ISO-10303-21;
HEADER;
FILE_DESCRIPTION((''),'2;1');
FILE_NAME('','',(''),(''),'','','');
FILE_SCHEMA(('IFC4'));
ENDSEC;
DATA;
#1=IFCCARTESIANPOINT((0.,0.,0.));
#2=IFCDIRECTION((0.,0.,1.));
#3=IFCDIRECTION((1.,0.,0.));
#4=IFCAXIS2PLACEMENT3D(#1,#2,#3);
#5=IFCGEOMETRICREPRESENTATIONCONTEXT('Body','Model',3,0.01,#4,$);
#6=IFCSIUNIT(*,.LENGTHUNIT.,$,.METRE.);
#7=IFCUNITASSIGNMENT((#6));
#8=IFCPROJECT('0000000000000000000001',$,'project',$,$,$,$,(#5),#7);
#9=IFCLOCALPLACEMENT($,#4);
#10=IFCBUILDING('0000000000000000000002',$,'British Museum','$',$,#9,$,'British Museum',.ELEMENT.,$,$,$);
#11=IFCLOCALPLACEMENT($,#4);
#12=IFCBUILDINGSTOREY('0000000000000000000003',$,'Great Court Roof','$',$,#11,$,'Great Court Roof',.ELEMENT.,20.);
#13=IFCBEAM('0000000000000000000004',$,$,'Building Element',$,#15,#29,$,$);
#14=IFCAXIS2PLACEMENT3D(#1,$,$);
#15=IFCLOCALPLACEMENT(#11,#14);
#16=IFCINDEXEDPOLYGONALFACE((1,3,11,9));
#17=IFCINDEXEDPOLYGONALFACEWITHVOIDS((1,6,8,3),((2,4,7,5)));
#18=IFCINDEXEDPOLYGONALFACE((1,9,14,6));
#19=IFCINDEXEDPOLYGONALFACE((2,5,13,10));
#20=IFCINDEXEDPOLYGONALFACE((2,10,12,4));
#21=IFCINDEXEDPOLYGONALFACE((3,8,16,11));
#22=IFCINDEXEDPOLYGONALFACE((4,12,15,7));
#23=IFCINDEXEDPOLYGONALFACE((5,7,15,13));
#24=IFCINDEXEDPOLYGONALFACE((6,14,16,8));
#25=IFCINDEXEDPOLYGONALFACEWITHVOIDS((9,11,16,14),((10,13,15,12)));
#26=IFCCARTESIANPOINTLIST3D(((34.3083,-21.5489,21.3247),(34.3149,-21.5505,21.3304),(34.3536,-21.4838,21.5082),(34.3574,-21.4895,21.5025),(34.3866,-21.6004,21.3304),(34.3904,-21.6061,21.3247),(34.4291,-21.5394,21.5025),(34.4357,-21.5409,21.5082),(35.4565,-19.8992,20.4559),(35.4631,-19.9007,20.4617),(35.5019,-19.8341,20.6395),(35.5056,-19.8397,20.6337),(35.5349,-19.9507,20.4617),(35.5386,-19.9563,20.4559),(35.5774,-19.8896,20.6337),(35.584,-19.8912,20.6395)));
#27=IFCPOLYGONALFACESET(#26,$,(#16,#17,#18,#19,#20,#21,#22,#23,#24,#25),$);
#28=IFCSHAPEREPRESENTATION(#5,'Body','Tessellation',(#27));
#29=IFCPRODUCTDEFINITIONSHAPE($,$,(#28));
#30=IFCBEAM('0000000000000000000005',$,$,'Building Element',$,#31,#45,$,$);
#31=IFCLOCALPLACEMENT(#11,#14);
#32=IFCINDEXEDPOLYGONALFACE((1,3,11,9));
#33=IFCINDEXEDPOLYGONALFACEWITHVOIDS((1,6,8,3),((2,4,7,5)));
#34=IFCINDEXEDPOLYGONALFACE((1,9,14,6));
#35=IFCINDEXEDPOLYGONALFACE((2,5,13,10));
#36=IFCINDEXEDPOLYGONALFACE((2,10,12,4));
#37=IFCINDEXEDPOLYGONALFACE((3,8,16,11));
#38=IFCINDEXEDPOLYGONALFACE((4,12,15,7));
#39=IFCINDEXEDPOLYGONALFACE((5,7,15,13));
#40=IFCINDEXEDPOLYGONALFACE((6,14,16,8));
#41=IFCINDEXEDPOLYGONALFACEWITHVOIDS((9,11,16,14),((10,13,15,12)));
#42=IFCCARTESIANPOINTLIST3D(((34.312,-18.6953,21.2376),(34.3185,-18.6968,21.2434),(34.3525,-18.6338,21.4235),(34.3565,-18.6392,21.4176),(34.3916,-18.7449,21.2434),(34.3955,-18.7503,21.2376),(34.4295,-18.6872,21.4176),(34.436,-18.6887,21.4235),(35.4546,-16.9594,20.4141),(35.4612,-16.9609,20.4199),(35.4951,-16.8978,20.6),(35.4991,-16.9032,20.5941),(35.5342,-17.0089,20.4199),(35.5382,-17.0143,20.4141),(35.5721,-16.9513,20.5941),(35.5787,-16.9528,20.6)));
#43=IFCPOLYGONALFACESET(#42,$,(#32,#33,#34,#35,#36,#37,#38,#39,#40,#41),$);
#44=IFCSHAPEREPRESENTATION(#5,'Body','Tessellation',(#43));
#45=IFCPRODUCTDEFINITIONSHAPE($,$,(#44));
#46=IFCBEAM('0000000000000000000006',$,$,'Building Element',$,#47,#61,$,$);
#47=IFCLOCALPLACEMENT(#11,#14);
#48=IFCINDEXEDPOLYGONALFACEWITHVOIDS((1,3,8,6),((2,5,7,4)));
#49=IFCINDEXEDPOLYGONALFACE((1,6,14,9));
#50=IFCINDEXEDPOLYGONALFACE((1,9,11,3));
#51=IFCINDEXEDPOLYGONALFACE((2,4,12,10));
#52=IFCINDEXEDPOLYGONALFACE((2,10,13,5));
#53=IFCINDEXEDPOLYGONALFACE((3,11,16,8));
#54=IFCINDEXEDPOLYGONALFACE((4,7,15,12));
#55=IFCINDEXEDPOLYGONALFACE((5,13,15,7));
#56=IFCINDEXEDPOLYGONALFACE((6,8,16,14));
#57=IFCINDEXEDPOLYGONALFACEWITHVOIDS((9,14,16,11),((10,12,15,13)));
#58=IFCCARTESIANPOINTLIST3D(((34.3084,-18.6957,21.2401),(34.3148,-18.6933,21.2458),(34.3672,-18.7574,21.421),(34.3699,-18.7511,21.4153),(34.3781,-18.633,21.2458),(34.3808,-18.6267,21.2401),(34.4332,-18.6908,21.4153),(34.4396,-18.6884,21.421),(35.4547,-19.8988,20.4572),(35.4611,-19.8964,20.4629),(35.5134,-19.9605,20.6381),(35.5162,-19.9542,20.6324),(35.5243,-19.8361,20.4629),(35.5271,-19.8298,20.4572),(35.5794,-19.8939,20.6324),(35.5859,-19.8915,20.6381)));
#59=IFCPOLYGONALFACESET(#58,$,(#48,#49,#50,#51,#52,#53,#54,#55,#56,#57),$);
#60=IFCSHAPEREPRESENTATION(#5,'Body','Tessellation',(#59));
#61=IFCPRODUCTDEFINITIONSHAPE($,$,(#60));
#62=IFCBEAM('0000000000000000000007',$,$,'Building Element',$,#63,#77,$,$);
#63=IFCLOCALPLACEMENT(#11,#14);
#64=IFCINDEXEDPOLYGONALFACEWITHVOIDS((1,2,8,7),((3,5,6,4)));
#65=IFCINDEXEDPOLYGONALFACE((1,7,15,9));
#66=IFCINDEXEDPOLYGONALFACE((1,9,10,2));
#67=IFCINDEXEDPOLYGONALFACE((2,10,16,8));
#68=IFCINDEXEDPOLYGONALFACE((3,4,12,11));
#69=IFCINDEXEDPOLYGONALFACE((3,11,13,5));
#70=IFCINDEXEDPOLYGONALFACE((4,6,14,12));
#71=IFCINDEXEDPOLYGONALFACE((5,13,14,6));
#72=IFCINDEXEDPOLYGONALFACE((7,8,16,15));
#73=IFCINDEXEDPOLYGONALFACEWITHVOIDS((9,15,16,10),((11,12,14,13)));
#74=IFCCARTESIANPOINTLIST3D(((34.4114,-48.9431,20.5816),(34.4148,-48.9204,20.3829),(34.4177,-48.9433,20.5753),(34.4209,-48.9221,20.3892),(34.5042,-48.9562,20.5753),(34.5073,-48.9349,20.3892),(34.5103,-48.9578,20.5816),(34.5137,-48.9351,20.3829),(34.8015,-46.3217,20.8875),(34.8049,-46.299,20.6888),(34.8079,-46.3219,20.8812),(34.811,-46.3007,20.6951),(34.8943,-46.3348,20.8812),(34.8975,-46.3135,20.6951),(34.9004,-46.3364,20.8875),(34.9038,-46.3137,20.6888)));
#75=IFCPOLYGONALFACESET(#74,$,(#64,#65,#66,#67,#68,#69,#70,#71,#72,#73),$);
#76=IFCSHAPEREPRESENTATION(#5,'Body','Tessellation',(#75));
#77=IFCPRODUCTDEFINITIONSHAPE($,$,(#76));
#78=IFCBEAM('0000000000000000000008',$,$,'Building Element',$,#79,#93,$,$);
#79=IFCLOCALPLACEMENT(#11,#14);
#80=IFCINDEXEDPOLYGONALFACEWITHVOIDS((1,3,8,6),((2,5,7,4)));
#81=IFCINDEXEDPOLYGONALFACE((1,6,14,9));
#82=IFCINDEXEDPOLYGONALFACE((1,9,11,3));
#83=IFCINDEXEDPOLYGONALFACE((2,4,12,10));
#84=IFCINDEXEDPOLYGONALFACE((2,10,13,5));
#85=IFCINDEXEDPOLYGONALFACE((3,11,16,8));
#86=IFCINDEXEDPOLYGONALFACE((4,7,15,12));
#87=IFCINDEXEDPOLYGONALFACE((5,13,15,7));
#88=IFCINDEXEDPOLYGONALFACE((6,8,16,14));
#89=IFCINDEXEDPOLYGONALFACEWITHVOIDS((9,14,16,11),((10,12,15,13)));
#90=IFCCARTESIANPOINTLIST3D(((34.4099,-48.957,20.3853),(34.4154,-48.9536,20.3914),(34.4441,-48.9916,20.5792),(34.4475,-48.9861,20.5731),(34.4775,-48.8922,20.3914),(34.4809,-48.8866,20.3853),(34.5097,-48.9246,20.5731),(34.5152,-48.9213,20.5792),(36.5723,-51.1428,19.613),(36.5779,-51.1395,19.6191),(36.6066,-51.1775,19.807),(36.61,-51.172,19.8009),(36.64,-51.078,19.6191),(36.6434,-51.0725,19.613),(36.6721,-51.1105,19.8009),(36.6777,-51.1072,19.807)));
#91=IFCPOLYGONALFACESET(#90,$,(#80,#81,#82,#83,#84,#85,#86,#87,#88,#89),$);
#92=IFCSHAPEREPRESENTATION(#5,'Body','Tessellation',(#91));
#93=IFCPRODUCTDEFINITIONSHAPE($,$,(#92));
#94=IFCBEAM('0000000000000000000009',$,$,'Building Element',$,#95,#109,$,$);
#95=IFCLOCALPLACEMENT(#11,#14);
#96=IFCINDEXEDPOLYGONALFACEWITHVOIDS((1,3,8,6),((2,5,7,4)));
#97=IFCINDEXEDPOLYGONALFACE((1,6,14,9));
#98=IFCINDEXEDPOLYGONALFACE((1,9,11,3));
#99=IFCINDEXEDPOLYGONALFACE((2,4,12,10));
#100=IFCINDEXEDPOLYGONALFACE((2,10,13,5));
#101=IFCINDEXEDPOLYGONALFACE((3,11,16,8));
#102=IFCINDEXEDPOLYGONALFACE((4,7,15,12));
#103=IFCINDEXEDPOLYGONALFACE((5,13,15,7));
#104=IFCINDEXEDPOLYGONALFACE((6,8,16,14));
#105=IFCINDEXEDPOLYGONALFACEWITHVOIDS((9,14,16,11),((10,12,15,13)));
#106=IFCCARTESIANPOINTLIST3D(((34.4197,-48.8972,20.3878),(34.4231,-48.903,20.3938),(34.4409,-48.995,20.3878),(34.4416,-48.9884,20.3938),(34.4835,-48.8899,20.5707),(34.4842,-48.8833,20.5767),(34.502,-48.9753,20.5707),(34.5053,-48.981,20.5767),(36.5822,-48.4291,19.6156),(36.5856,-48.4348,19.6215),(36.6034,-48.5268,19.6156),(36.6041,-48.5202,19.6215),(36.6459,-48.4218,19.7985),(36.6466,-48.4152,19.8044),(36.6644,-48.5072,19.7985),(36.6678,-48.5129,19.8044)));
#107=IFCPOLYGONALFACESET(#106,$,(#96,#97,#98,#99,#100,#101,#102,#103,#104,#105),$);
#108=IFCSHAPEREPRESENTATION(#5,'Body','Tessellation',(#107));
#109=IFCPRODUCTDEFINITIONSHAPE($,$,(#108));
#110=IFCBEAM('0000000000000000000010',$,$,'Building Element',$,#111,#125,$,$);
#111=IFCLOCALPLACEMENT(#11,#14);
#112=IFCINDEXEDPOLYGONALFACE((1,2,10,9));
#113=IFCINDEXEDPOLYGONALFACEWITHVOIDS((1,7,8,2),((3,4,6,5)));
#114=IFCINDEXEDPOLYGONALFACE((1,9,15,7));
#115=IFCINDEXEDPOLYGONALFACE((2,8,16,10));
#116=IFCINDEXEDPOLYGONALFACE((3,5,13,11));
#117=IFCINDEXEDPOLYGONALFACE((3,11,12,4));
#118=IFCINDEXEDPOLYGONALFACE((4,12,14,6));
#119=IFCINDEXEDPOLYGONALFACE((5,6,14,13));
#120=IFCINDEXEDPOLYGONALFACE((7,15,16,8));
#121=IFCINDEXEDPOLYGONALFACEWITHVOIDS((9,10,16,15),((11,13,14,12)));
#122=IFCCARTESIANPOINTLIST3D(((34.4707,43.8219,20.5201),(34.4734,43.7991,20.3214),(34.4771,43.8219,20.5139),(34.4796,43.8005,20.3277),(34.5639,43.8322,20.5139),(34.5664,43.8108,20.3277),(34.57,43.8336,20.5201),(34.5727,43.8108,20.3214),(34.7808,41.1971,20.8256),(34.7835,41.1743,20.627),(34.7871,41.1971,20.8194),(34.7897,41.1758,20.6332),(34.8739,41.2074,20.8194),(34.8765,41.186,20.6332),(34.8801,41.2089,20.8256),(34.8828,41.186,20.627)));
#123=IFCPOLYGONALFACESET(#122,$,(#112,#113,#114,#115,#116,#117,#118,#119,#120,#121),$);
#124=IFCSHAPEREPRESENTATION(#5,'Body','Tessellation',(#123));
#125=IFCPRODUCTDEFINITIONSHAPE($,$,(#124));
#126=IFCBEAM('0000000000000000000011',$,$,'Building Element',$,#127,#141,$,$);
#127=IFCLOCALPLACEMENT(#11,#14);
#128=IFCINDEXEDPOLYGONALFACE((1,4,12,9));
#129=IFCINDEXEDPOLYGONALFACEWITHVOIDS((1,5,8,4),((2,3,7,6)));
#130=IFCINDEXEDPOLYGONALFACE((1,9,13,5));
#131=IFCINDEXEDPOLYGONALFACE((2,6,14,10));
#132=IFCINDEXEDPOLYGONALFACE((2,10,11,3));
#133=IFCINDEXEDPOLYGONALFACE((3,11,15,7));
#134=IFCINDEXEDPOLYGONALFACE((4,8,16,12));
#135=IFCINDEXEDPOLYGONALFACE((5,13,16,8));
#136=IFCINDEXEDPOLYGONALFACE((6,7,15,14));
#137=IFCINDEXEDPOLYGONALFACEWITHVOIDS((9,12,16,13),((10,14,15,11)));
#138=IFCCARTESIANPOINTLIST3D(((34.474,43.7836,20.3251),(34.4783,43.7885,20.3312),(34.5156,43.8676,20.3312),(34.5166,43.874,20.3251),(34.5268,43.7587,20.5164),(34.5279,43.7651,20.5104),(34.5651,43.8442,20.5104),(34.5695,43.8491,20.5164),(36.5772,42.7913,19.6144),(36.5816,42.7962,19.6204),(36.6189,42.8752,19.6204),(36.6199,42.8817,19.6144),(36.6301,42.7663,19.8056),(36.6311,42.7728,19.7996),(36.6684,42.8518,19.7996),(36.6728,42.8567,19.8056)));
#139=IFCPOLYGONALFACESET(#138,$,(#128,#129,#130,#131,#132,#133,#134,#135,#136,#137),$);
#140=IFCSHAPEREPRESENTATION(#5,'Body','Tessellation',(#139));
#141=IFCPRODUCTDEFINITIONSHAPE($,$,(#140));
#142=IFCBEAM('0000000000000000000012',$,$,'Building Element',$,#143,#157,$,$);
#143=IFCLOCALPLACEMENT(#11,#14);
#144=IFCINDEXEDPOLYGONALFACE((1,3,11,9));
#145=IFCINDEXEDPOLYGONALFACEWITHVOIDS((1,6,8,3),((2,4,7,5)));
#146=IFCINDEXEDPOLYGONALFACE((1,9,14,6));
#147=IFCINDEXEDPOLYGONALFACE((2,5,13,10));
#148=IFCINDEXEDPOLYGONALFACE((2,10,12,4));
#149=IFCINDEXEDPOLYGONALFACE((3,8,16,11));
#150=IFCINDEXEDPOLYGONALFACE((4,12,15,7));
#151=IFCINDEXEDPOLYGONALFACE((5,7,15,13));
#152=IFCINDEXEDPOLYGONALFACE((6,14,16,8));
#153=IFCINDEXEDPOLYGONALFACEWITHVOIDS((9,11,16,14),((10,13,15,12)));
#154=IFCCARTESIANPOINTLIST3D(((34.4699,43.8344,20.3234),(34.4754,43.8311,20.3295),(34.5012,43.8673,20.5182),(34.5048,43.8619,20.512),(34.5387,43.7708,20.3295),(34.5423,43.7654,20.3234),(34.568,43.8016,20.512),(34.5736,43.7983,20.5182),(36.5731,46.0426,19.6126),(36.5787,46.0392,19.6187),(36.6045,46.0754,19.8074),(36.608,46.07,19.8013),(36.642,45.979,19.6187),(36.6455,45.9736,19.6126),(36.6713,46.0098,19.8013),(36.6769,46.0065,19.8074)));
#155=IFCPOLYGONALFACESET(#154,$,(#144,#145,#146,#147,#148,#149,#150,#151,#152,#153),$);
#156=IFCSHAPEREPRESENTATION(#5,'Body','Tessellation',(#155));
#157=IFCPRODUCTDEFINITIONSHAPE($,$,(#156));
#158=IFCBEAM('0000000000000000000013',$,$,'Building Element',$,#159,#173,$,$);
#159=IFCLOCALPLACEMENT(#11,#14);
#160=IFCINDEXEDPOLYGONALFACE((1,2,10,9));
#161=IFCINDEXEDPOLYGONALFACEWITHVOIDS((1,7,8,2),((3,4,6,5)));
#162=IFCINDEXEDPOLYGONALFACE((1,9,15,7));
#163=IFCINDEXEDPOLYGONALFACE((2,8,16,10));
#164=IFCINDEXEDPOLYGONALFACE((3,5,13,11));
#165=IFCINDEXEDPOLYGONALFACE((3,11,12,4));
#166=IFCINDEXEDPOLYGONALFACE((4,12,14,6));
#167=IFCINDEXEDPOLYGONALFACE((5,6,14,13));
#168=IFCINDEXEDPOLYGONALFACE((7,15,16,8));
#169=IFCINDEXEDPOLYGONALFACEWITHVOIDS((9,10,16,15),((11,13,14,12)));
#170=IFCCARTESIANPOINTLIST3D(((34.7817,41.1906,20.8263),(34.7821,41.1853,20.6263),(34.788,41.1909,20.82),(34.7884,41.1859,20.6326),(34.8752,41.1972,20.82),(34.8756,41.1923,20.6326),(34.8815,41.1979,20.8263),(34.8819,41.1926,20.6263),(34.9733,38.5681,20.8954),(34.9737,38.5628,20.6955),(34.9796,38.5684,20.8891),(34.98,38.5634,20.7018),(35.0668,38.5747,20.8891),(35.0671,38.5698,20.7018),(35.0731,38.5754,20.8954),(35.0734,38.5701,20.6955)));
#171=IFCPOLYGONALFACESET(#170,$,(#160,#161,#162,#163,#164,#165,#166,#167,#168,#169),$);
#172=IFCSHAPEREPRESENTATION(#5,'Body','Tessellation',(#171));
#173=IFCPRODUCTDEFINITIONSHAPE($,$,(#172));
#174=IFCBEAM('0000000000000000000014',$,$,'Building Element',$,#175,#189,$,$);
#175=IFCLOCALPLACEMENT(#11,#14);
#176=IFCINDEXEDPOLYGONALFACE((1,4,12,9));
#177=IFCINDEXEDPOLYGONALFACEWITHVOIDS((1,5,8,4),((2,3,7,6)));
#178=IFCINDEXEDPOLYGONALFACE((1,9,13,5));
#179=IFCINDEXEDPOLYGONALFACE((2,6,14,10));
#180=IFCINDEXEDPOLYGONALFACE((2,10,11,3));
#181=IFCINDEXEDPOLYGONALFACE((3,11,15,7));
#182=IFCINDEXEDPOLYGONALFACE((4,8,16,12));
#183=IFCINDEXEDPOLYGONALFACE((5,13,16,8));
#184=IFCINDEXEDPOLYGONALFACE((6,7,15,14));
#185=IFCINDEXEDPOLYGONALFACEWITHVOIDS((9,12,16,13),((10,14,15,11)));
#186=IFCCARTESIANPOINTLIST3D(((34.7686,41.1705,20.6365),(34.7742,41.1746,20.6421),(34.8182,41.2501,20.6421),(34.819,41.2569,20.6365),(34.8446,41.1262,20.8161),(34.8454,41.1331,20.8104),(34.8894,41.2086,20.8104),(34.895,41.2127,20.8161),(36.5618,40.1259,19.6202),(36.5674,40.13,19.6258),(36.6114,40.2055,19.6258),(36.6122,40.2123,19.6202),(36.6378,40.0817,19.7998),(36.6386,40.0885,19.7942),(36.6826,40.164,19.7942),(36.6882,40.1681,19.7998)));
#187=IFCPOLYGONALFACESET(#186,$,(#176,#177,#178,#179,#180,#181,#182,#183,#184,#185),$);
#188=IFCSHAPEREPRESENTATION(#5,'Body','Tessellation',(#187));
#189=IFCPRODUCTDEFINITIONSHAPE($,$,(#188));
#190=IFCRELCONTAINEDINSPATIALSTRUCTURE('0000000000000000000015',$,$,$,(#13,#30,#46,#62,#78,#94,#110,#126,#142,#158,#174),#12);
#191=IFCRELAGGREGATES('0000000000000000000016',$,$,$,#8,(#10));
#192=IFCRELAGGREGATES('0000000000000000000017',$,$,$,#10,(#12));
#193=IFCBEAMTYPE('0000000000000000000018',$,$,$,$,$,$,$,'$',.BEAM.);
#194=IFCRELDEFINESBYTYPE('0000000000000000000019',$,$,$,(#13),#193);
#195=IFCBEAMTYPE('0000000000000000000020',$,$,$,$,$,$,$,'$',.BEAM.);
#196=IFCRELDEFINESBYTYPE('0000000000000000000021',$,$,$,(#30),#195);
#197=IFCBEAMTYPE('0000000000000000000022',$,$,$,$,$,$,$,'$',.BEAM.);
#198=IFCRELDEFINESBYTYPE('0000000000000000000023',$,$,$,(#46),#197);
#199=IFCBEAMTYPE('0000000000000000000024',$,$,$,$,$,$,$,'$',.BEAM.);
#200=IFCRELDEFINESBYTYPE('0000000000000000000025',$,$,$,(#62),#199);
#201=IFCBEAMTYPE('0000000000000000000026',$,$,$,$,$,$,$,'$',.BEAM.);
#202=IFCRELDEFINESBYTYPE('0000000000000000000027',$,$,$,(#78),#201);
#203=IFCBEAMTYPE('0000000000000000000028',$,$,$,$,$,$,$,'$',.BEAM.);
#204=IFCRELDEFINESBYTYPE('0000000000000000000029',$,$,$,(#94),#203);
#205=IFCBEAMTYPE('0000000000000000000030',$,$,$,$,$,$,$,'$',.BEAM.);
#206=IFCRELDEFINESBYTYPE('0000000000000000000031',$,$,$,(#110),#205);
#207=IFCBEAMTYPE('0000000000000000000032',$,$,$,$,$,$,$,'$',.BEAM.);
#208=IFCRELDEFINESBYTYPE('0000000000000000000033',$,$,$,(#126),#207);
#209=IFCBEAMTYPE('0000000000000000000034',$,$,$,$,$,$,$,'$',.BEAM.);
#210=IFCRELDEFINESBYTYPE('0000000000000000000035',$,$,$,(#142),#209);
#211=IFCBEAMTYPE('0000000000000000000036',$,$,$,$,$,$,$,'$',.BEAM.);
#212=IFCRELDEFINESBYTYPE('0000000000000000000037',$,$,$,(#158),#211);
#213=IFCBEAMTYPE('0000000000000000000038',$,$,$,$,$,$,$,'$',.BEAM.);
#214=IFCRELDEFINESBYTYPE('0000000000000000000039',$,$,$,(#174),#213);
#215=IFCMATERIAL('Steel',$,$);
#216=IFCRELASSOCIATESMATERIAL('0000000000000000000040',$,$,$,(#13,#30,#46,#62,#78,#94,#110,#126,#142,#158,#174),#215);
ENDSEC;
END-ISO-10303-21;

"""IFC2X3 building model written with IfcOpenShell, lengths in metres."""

from ifc_helpers import new_model, si_unit, frame, origin_with_axes, origin_2d, place, context, project, spatial, hollow_rectangle, extrude, material, type_object, element, save


model = new_model("IFC2X3")

# Units and contexts
model_context = context("Model", 3, precision=0.01, world=origin_with_axes(), identifier="Body")
ifc_project = project(units=[si_unit("LENGTHUNIT", "METRE")], contexts=[model_context])

# Building, storey
building_placement = place(None, origin_with_axes())
building = spatial("IfcBuilding", under=ifc_project, at=building_placement, Name="British Museum", Description="$", LongName="British Museum", CompositionType="ELEMENT")
storey_placement = place(None, origin_with_axes())
storey = spatial("IfcBuildingStorey", under=building, at=storey_placement, Name="Great Court Roof", Description="$", LongName="Great Court Roof", CompositionType="ELEMENT", Elevation=20.0)

# Beams
ifc_material = material(Name="Steel")
beam_type_1 = type_object("IfcBeamType", ElementType="$", PredefinedType="BEAM")
beam_1_placement = place(None, origin_with_axes())
element("IfcBeam", 1, at=beam_1_placement, inside=storey, type_object=beam_type_1, material=ifc_material, Description="Building Element", context=model_context, shape_type="SweptSolid", body=[
    extrude(hollow_rectangle(XDim=0.1, YDim=0.2, WallThickness=0.0063, InnerFilletRadius=-0.0063, OuterFilletRadius=0.0, at=origin_2d()), frame((34.372, -21.5449, 21.4164), z_axis=(0.524373, 0.753405, -0.396754), x_axis=(-0.82077, 0.571259, 0.0)), (0.0, 0.0, 1.0), 2.1897),
])
beam_type_2 = type_object("IfcBeamType", ElementType="$", PredefinedType="BEAM")
beam_2_placement = place(None, origin_with_axes())
element("IfcBeam", 2, at=beam_2_placement, inside=storey, type_object=beam_type_2, material=ifc_material, Description="Building Element", context=model_context, shape_type="SweptSolid", body=[
    extrude(hollow_rectangle(XDim=0.1, YDim=0.2, WallThickness=0.0063, InnerFilletRadius=-0.0063, OuterFilletRadius=0.0, at=origin_2d()), frame((34.374, -18.692, 21.3305), z_axis=(0.511137, 0.776554, -0.368379), x_axis=(-0.835295, 0.549802, 0.0)), (0.0, 0.0, 1.0), 2.2354),
])
beam_type_3 = type_object("IfcBeamType", ElementType="$", PredefinedType="BEAM")
beam_3_placement = place(None, origin_with_axes())
element("IfcBeam", 3, at=beam_3_placement, inside=storey, type_object=beam_type_3, material=ifc_material, Description="Building Element", context=model_context, shape_type="SweptSolid", body=[
    extrude(hollow_rectangle(XDim=0.1, YDim=0.2, WallThickness=0.0063, InnerFilletRadius=-0.0063, OuterFilletRadius=0.0, at=origin_2d()), frame((34.374, -18.692, 21.3305), z_axis=(0.623992, -0.654984, -0.426181), x_axis=(0.724029, 0.68977, 0.0)), (0.0, 0.0, 1.0), 1.8369),
])
beam_type_4 = type_object("IfcBeamType", ElementType="$", PredefinedType="BEAM")
beam_4_placement = place(None, origin_with_axes())
element("IfcBeam", 4, at=beam_4_placement, inside=storey, type_object=beam_type_4, material=ifc_material, Description="Building Element", context=model_context, shape_type="SweptSolid", body=[
    extrude(hollow_rectangle(XDim=0.1, YDim=0.2, WallThickness=0.0063, InnerFilletRadius=-0.0063, OuterFilletRadius=0.0, at=origin_2d()), frame((34.4625, -48.9391, 20.4822), z_axis=(0.146239, 0.982582, 0.114658), x_axis=(-0.989105, 0.14721, 0.0)), (0.0, 0.0, 1.0), 2.6679),
])
beam_type_5 = type_object("IfcBeamType", ElementType="$", PredefinedType="BEAM")
beam_5_placement = place(None, origin_with_axes())
element("IfcBeam", 5, at=beam_5_placement, inside=storey, type_object=beam_type_5, material=ifc_material, Description="Building Element", context=model_context, shape_type="SweptSolid", body=[
    extrude(hollow_rectangle(XDim=0.1, YDim=0.2, WallThickness=0.0063, InnerFilletRadius=-0.0063, OuterFilletRadius=0.0, at=origin_2d()), frame((34.4625, -48.9391, 20.4822), z_axis=(0.682107, -0.689489, -0.24359), x_axis=(0.710902, 0.703291, 0.0)), (0.0, 0.0, 1.0), 3.1703),
])
beam_type_6 = type_object("IfcBeamType", ElementType="$", PredefinedType="BEAM")
beam_6_placement = place(None, origin_with_axes())
element("IfcBeam", 6, at=beam_6_placement, inside=storey, type_object=beam_type_6, material=ifc_material, Description="Building Element", context=model_context, shape_type="SweptSolid", body=[
    extrude(hollow_rectangle(XDim=0.1, YDim=0.2, WallThickness=0.0063, InnerFilletRadius=-0.0063, OuterFilletRadius=0.0, at=origin_2d()), frame((34.4625, -48.9391, 20.4822), z_axis=(0.922769, 0.19976, -0.329534), x_axis=(-0.211578, 0.977361, 0.0)), (0.0, 0.0, 1.0), 2.3435),
])
beam_type_7 = type_object("IfcBeamType", ElementType="$", PredefinedType="BEAM")
beam_7_placement = place(None, origin_with_axes())
element("IfcBeam", 7, at=beam_7_placement, inside=storey, type_object=beam_type_7, material=ifc_material, Description="Building Element", context=model_context, shape_type="SweptSolid", body=[
    extrude(hollow_rectangle(XDim=0.1, YDim=0.2, WallThickness=0.0063, InnerFilletRadius=-0.0063, OuterFilletRadius=0.0, at=origin_2d()), frame((34.5217, 43.8164, 20.4208), z_axis=(0.116539, -0.986526, 0.114828), x_axis=(0.993095, 0.117315, 0.0)), (0.0, 0.0, 1.0), 2.6606),
])
beam_type_8 = type_object("IfcBeamType", ElementType="$", PredefinedType="BEAM")
beam_8_placement = place(None, origin_with_axes())
element("IfcBeam", 8, at=beam_8_placement, inside=storey, type_object=beam_type_8, material=ifc_material, Description="Building Element", context=model_context, shape_type="SweptSolid", body=[
    extrude(hollow_rectangle(XDim=0.1, YDim=0.2, WallThickness=0.0063, InnerFilletRadius=-0.0063, OuterFilletRadius=0.0, at=origin_2d()), frame((34.5217, 43.8164, 20.4208), z_axis=(0.864897, -0.408072, -0.292285), x_axis=(0.426706, 0.904391, 0.0)), (0.0, 0.0, 1.0), 2.4318),
])
beam_type_9 = type_object("IfcBeamType", ElementType="$", PredefinedType="BEAM")
beam_9_placement = place(None, origin_with_axes())
element("IfcBeam", 9, at=beam_9_placement, inside=storey, type_object=beam_type_9, material=ifc_material, Description="Building Element", context=model_context, shape_type="SweptSolid", body=[
    extrude(hollow_rectangle(XDim=0.1, YDim=0.2, WallThickness=0.0063, InnerFilletRadius=-0.0063, OuterFilletRadius=0.0, at=origin_2d()), frame((34.5217, 43.8164, 20.4208), z_axis=(0.671699, 0.705191, -0.226995), x_axis=(-0.724093, 0.689703, 0.0)), (0.0, 0.0, 1.0), 3.1313),
])
beam_type_10 = type_object("IfcBeamType", ElementType="$", PredefinedType="BEAM")
beam_10_placement = place(None, origin_with_axes())
element("IfcBeam", 10, at=beam_10_placement, inside=storey, type_object=beam_type_10, material=ifc_material, Description="Building Element", context=model_context, shape_type="SweptSolid", body=[
    extrude(hollow_rectangle(XDim=0.1, YDim=0.2, WallThickness=0.0063, InnerFilletRadius=-0.0063, OuterFilletRadius=0.0, at=origin_2d()), frame((34.8318, 41.1916, 20.7263), z_axis=(0.072834, -0.996997, 0.026302), x_axis=(0.997342, 0.072859, 0.0)), (0.0, 0.0, 1.0), 2.6304),
])
beam_type_11 = type_object("IfcBeamType", ElementType="$", PredefinedType="BEAM")
beam_11_placement = place(None, origin_with_axes())
element("IfcBeam", 11, at=beam_11_placement, inside=storey, type_object=beam_type_11, material=ifc_material, Description="Building Element", context=model_context, shape_type="SweptSolid", body=[
    extrude(hollow_rectangle(XDim=0.1, YDim=0.2, WallThickness=0.0063, InnerFilletRadius=-0.0063, OuterFilletRadius=0.0, at=origin_2d()), frame((34.8318, 41.1916, 20.7263), z_axis=(0.776024, -0.452054, -0.439811), x_axis=(0.50335, 0.864083, 0.0)), (0.0, 0.0, 1.0), 2.3108),
])

save(model, "model.ifc")
